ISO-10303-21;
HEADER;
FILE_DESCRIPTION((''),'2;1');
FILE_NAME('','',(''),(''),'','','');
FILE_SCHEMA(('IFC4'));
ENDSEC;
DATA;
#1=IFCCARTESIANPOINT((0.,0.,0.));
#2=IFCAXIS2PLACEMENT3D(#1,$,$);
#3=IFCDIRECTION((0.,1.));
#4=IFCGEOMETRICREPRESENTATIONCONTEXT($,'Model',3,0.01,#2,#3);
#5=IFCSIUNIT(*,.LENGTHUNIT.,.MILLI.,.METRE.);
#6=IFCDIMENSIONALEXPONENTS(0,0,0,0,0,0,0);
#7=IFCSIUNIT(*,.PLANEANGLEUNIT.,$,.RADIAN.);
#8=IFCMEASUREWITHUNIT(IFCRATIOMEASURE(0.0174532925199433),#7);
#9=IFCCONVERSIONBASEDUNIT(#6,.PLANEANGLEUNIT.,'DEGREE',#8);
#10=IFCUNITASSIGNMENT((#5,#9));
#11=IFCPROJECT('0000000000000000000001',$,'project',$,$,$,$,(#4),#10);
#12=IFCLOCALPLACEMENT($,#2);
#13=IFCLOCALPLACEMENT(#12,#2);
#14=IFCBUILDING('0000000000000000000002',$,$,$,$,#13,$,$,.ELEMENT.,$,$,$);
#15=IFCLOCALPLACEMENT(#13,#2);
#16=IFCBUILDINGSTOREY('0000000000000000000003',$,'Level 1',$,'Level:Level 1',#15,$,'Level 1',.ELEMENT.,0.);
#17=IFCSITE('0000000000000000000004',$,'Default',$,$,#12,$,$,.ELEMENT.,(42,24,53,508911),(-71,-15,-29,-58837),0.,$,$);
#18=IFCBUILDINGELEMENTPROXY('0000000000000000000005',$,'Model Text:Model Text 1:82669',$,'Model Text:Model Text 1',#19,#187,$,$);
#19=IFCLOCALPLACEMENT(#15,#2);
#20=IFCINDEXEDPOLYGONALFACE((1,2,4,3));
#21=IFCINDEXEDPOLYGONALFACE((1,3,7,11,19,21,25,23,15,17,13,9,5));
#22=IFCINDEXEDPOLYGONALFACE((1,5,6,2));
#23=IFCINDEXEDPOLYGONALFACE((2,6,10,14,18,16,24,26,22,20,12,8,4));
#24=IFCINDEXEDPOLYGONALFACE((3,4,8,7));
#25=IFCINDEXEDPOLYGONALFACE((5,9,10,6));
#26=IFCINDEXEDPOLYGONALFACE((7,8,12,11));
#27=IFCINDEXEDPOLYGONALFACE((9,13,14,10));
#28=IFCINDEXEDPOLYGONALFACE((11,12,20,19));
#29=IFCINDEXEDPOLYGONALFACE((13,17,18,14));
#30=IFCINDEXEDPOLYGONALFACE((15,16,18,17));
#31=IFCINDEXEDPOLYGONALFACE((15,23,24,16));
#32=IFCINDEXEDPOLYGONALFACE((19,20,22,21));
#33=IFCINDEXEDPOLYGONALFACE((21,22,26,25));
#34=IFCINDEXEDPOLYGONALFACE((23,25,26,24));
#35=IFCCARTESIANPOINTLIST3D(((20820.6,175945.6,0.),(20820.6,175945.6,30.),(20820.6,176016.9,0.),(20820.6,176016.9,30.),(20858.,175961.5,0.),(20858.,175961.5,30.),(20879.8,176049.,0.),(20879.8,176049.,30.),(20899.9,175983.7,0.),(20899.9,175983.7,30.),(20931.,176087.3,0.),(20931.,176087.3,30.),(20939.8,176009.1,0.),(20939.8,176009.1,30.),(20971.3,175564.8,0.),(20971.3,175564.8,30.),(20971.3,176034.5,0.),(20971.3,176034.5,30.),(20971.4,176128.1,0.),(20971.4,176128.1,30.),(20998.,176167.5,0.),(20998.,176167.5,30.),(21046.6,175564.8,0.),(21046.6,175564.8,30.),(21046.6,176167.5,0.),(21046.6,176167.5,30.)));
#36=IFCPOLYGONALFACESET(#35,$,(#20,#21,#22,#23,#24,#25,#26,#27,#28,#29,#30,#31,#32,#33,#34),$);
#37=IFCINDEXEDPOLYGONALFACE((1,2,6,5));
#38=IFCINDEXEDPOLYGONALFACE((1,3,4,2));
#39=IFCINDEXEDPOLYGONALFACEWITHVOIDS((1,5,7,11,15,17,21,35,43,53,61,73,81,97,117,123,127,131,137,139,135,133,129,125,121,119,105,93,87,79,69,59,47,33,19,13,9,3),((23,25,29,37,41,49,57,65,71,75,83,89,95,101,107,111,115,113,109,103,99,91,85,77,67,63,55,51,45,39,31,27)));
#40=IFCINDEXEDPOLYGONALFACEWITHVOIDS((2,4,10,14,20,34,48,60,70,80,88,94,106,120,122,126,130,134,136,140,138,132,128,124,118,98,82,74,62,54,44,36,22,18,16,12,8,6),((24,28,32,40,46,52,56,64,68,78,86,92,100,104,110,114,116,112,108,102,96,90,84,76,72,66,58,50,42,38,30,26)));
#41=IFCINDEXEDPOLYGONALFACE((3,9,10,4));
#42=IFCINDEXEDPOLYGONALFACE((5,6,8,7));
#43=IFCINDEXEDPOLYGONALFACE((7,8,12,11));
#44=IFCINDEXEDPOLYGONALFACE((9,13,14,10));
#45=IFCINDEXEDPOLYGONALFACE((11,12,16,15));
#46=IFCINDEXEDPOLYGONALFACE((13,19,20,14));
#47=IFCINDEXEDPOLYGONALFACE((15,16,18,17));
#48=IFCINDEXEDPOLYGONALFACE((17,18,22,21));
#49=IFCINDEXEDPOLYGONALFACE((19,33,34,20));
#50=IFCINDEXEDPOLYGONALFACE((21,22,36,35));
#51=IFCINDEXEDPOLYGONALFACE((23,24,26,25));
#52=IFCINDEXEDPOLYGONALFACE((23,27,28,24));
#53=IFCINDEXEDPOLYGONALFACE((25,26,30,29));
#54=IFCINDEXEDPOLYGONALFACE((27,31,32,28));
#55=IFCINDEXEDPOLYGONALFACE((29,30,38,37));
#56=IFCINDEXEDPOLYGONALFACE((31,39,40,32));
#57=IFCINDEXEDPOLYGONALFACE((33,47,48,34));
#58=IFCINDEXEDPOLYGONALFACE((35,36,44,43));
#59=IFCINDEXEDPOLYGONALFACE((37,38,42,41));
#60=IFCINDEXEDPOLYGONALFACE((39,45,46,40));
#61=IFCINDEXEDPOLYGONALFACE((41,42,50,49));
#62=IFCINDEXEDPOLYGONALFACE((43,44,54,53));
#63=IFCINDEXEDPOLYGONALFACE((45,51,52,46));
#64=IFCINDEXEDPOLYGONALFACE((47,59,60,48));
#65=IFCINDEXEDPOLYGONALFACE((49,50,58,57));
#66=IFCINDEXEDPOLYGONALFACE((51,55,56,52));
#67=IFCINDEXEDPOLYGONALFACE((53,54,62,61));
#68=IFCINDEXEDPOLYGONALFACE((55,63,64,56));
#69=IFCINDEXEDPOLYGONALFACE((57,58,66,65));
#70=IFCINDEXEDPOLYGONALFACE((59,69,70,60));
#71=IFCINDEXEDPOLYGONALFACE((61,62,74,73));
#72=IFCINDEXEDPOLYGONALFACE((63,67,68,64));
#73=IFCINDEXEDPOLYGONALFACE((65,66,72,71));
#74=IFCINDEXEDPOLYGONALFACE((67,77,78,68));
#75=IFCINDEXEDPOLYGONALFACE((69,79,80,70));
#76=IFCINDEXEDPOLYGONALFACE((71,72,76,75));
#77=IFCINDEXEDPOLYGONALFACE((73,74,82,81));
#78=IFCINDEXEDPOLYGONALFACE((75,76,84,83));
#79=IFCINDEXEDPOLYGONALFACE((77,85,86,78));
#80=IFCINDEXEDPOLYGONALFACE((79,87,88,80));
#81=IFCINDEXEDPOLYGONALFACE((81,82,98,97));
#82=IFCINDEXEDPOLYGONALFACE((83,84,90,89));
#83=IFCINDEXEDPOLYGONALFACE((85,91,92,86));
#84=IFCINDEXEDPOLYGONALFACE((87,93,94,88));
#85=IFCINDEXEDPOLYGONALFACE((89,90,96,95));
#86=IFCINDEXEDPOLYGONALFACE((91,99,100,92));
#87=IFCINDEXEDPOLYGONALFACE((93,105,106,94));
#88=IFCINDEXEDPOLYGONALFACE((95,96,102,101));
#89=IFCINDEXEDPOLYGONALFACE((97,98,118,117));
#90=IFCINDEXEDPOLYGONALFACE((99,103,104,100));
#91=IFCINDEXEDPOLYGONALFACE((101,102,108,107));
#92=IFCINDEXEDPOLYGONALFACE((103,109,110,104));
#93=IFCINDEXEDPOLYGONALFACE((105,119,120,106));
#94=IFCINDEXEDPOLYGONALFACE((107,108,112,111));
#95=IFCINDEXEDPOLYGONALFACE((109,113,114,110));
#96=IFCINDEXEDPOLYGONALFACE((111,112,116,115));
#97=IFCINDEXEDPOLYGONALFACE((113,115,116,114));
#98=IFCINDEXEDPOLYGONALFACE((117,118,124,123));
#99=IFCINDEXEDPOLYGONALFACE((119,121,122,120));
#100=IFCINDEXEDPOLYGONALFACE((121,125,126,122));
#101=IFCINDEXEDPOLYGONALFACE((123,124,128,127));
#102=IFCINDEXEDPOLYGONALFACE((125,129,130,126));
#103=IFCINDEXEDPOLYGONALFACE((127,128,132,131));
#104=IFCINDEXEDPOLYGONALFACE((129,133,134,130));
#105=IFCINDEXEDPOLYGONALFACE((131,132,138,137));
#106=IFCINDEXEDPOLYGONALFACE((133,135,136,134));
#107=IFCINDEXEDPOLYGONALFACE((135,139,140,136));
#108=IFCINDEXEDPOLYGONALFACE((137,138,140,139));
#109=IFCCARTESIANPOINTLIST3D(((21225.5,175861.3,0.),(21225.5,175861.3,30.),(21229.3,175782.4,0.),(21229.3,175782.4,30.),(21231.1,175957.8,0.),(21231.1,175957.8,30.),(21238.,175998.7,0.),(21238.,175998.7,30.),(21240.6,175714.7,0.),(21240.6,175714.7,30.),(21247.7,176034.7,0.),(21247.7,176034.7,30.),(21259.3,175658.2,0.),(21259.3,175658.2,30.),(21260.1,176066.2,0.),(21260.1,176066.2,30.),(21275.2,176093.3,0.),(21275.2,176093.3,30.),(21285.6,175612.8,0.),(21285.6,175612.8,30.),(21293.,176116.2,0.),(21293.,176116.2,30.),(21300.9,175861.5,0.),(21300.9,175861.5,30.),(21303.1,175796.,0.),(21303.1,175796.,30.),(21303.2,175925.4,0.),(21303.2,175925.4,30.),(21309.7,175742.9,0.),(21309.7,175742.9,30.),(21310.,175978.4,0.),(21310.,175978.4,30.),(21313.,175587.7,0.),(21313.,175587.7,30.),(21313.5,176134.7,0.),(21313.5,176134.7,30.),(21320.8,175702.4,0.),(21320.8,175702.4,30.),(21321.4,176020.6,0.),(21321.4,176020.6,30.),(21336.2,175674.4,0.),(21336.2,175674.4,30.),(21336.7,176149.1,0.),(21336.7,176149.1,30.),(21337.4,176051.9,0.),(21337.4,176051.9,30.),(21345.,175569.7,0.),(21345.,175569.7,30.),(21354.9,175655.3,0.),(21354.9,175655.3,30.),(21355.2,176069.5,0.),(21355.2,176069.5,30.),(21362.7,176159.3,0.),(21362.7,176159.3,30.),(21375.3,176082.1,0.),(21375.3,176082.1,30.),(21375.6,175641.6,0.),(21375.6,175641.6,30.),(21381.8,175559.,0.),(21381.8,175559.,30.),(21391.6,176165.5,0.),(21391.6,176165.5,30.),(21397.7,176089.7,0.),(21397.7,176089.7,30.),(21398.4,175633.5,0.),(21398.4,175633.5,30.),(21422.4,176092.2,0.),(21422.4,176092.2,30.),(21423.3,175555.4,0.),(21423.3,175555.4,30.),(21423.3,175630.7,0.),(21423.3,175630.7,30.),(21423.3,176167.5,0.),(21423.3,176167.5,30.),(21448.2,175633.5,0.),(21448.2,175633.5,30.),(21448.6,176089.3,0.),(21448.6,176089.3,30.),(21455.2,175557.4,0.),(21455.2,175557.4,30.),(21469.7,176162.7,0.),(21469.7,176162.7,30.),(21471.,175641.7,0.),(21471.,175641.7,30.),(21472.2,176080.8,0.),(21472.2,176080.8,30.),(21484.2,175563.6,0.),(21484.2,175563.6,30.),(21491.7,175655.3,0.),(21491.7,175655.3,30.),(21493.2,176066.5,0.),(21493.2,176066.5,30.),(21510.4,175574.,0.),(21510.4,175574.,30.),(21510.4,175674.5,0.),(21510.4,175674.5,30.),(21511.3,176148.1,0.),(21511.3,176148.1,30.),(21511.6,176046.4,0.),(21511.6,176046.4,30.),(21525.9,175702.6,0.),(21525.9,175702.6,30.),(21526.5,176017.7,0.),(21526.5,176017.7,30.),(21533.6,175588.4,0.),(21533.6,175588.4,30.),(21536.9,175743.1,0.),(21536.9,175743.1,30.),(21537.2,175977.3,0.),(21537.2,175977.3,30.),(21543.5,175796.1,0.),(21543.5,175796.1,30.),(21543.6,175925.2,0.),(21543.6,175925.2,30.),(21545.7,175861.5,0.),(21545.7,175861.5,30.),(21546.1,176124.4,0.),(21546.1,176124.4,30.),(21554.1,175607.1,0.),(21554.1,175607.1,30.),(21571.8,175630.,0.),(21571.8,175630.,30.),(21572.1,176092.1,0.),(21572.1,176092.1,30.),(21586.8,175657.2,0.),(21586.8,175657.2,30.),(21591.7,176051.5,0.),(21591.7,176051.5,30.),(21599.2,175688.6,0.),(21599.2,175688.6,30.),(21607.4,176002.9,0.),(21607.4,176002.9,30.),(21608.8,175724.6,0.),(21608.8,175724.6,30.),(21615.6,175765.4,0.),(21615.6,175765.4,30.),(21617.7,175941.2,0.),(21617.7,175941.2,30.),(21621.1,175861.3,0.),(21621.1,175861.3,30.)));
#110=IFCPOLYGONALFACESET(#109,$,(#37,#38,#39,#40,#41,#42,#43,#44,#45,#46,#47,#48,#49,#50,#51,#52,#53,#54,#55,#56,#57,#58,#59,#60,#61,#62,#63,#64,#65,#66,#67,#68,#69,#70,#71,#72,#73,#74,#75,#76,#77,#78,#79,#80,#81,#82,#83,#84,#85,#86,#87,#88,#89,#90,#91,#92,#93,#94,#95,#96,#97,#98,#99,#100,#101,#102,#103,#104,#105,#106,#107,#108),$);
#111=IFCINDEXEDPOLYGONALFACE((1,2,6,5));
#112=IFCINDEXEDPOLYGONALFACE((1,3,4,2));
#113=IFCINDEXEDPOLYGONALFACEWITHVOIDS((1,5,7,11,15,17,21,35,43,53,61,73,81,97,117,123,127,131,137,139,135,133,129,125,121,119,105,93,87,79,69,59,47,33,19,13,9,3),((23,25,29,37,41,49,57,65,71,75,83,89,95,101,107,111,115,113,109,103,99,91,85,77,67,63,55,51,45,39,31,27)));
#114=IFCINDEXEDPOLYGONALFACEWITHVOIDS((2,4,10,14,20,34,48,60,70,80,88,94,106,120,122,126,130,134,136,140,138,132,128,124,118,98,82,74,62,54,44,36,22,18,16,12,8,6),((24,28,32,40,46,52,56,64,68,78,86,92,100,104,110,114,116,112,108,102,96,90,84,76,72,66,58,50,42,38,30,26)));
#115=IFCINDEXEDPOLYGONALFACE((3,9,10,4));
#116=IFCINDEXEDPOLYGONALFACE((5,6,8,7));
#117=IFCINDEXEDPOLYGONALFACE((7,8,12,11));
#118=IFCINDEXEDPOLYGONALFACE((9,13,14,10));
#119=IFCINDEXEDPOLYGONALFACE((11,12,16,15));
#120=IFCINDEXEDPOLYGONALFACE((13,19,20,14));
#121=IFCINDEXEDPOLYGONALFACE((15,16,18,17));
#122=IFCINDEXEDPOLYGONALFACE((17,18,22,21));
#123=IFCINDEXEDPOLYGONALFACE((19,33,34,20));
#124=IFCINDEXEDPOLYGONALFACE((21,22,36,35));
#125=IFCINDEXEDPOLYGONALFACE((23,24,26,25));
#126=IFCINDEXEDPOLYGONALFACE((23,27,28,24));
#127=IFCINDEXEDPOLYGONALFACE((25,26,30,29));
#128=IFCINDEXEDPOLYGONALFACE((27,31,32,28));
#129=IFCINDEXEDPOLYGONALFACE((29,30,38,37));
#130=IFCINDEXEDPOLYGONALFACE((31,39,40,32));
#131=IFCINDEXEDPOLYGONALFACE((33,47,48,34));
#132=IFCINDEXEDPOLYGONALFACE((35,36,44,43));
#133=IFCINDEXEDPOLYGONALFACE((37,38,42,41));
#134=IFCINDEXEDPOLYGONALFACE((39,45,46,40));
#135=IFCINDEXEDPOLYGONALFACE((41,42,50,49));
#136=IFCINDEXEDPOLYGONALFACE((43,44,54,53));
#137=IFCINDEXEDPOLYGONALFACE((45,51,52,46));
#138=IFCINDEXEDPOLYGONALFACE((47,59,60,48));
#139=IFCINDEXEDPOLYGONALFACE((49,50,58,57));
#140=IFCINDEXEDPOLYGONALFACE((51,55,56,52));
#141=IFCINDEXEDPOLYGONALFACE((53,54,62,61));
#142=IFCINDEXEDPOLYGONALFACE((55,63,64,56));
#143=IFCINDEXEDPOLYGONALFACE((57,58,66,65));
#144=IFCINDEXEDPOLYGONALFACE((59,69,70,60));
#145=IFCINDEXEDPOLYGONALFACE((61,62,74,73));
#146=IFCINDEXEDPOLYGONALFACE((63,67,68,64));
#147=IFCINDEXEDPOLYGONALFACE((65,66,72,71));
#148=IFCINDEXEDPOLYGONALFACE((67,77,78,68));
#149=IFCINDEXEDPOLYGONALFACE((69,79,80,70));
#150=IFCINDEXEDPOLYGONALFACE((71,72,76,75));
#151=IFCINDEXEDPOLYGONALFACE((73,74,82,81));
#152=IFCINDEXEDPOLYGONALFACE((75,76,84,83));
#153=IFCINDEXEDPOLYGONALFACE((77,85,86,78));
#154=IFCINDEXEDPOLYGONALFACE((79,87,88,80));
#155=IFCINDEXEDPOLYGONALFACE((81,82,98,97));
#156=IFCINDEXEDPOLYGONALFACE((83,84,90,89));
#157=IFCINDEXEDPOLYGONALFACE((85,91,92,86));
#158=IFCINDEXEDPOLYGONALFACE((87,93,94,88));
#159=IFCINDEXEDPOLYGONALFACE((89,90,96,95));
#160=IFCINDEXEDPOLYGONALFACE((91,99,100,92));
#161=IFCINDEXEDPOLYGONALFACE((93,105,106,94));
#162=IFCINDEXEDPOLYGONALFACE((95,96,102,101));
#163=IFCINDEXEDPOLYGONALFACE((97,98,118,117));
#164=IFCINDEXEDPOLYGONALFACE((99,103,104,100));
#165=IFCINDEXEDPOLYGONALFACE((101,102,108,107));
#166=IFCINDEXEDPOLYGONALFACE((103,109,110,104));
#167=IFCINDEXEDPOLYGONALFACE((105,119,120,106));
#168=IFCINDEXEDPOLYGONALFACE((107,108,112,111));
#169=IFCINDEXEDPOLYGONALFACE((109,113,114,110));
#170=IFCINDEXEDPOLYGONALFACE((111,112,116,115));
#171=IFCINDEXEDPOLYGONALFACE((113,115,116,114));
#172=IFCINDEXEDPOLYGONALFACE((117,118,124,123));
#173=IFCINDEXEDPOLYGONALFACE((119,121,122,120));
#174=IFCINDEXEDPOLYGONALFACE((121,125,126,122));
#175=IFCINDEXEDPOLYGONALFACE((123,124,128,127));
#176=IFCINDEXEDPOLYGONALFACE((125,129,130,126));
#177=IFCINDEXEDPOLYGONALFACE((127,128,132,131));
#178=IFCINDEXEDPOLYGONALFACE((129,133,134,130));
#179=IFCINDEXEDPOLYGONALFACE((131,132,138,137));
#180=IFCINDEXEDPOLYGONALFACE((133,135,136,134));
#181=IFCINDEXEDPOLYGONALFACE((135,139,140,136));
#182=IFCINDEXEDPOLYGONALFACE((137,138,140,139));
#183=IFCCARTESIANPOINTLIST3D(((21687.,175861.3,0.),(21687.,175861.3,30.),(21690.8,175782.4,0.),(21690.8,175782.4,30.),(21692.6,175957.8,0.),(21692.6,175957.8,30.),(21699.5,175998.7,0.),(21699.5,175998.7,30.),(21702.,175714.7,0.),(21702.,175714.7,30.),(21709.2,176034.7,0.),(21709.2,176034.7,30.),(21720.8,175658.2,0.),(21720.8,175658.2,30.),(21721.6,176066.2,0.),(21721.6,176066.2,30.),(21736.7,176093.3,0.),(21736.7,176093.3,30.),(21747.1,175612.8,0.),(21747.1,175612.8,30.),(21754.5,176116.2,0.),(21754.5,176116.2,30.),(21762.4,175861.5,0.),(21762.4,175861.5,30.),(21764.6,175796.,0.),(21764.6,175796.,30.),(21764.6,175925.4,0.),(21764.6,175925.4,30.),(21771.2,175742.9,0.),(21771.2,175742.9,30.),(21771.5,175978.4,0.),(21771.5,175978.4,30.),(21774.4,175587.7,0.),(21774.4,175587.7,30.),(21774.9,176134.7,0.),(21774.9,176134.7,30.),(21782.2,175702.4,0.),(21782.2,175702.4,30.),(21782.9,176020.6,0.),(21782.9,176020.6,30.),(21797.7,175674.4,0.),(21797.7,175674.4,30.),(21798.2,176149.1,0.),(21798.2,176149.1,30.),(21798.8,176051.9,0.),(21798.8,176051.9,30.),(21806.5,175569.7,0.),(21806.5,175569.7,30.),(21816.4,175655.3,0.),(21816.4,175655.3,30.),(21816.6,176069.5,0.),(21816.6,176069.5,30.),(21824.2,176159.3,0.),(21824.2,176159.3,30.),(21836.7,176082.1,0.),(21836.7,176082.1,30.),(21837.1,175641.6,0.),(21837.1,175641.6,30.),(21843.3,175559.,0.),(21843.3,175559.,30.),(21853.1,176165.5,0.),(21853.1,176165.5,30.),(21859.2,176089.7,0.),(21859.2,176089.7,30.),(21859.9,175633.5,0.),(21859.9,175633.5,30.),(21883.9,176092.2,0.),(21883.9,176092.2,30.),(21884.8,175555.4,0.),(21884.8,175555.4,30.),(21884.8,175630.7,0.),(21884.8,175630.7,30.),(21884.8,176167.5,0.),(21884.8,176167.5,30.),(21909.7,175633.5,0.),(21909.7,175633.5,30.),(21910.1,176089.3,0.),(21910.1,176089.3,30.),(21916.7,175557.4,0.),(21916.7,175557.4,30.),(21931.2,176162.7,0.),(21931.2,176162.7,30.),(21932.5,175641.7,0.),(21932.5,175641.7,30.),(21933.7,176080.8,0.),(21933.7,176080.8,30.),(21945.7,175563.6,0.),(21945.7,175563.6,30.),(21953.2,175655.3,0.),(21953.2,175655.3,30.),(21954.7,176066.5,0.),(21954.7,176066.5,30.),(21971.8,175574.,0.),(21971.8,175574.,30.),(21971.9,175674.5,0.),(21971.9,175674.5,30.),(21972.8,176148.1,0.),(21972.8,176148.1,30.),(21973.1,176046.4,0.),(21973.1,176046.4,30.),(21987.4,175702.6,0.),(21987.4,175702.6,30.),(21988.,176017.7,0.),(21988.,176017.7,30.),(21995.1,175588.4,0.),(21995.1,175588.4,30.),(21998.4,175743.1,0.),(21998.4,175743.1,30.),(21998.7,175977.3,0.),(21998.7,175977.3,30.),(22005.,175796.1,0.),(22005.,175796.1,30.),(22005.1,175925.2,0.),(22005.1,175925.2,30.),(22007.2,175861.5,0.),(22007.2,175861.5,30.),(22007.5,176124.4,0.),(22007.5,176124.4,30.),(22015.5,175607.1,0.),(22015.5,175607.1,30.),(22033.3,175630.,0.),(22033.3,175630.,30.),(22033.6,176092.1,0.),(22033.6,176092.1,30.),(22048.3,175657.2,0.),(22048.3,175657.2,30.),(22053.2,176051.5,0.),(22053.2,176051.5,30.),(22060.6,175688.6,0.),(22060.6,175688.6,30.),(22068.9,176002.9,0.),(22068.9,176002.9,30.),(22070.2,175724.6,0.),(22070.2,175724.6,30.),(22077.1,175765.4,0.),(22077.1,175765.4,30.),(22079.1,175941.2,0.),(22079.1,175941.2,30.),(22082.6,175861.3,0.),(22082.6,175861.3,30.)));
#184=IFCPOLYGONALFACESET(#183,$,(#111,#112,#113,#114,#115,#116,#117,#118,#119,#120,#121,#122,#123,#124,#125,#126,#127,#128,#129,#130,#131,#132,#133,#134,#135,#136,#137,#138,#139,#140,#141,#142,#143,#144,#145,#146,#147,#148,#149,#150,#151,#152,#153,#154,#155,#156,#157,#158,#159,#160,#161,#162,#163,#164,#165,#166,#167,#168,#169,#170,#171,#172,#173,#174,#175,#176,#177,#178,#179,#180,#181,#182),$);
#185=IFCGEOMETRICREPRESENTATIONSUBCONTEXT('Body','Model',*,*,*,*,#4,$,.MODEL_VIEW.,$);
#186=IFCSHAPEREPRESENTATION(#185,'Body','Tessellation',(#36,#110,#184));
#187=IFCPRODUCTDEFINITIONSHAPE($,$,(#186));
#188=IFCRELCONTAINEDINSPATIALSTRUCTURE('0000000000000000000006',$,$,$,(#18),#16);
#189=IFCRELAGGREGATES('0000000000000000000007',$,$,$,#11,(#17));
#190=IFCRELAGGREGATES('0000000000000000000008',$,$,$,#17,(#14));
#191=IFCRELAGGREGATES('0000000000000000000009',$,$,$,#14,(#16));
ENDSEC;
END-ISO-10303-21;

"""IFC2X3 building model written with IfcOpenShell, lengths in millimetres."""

from ifc_helpers import new_model, entity, si_unit, converted_unit, direction, frame, origin, place, context, subcontext, project, spatial, polyline, outline, extrude, element, save


model = new_model("IFC2X3")

# Units and contexts
model_context = context("Model", 3, precision=0.01, world=origin(), true_north=direction((0.0, 1.0)))
body_context = subcontext(model_context, "Body", "Model", "MODEL_VIEW")
ifc_project = project(units=[si_unit("LENGTHUNIT", "METRE", prefix="MILLI"), converted_unit("PLANEANGLEUNIT", "DEGREE", entity("IfcRatioMeasure", 0.0174532925199433), si_unit("PLANEANGLEUNIT", "RADIAN"), dimensions=[0, 0, 0, 0, 0, 0, 0])], contexts=[model_context])

# Site, building, storey
site_placement = place(None, origin())
site = spatial("IfcSite", under=ifc_project, at=site_placement, Name="Default", CompositionType="ELEMENT", RefLatitude=(42, 24, 53, 508911), RefLongitude=(-71, -15, -29, -58837), RefElevation=0.0)
building_placement = place(site_placement, origin())
building = spatial("IfcBuilding", under=site, at=building_placement, CompositionType="ELEMENT")
storey_placement = place(building_placement, origin())
storey = spatial("IfcBuildingStorey", under=building, at=storey_placement, Name="Level 1", ObjectType="Level:Level 1", LongName="Level 1", CompositionType="ELEMENT", Elevation=0.0)

# Building element proxy
proxy_1_placement = place(storey_placement, origin())
element("IfcBuildingElementProxy", 1, at=proxy_1_placement, inside=storey, Name="Model Text:Model Text 1:82669", ObjectType="Model Text:Model Text 1", context=body_context, shape_type="SweptSolid", body=[
    extrude(outline(polyline([(-410.6, -111.6), (192.1, -111.6), (192.1, -63.1), (152.7, -36.4), (111.9, 4.0), (73.6, 55.2), (41.4, 114.4), (-29.8, 114.4), (-13.9, 77.0), (8.3, 35.1), (33.7, -4.8), (59.1, -36.3), (-410.6, -36.3), (-410.6, -111.6)])), frame((20935.0, 175975.4, 0.0), z_axis=(0.0, 0.0, 1.0), x_axis=(0.0, 1.0, 0.0)), (0.0, 0.0, 1.0), 30.0),
    extrude(outline(polyline([(-10.6, -198.7), (68.3, -198.7), (136.5, -190.7), (193.9, -174.7), (240.5, -150.6), (266.9, -124.4), (286.3, -93.2), (298.8, -57.0), (304.3, -15.7), (303.8, 16.2), (299.0, 45.5), (289.9, 72.1), (276.6, 96.0), (258.9, 117.3), (236.9, 136.2), (210.4, 152.5), (179.6, 166.3), (144.1, 177.6), (103.7, 186.3), (8.2, 196.4), (-71.8, 196.7), (-134.0, 189.4), (-183.3, 176.1), (-224.7, 158.4), (-258.2, 133.9), (-283.5, 100.3), (-300.1, 59.5), (-307.1, 13.4), (-306.6, -18.4), (-301.8, -47.5), (-292.8, -74.0), (-279.6, -97.9), (-262.0, -119.2), (-240.0, -138.1), (-213.6, -154.5), (-182.8, -168.4), (-147.3, -179.8), (-106.7, -188.6), (-10.6, -198.7)]), holes=[polyline([(-7.2, -123.5), (-71.0, -118.2), (-123.6, -108.8), (-165.2, -95.4), (-195.7, -78.0), (-212.4, -59.4), (-224.1, -38.7), (-230.6, -15.9), (-231.9, 8.9), (-227.8, 35.0), (-218.1, 58.1), (-202.8, 78.4), (-182.0, 95.8), (-152.6, 109.4), (-111.7, 118.1), (-59.4, 122.0), (4.4, 121.1), (69.6, 115.8), (122.2, 106.7), (162.2, 93.7), (189.5, 77.0), (207.7, 57.4), (220.4, 36.0), (227.5, 12.8), (229.1, -12.1), (225.2, -36.8), (215.9, -59.2), (201.3, -79.3), (181.4, -97.1), (152.6, -111.2), (111.6, -120.3), (58.3, -124.4), (-7.2, -123.5)])]), frame((21424.6, 175860.1, 0.0), z_axis=(0.0, 0.0, 1.0), x_axis=(0.047515, -0.998871, 0.0)), (0.0, 0.0, 1.0), 30.0),
    extrude(outline(polyline([(-10.6, -198.7), (68.3, -198.7), (136.5, -190.7), (193.9, -174.7), (240.5, -150.6), (266.9, -124.4), (286.3, -93.2), (298.8, -57.0), (304.3, -15.7), (303.8, 16.2), (299.0, 45.5), (289.9, 72.1), (276.6, 96.0), (258.9, 117.3), (236.9, 136.2), (210.4, 152.5), (179.6, 166.3), (144.1, 177.6), (103.7, 186.3), (8.2, 196.4), (-71.8, 196.7), (-134.0, 189.4), (-183.3, 176.1), (-224.7, 158.4), (-258.2, 133.9), (-283.5, 100.3), (-300.1, 59.5), (-307.1, 13.4), (-306.6, -18.4), (-301.8, -47.5), (-292.8, -74.0), (-279.6, -97.9), (-262.0, -119.2), (-240.0, -138.1), (-213.6, -154.5), (-182.8, -168.4), (-147.3, -179.8), (-106.7, -188.6), (-10.6, -198.7)]), holes=[polyline([(-7.2, -123.5), (-71.0, -118.2), (-123.6, -108.8), (-165.2, -95.4), (-195.7, -78.0), (-212.4, -59.4), (-224.1, -38.7), (-230.6, -15.9), (-231.9, 8.9), (-227.8, 35.0), (-218.1, 58.1), (-202.8, 78.4), (-182.0, 95.8), (-152.6, 109.4), (-111.7, 118.1), (-59.4, 122.0), (4.4, 121.1), (69.6, 115.8), (122.2, 106.7), (162.2, 93.7), (189.5, 77.0), (207.7, 57.4), (220.4, 36.0), (227.5, 12.8), (229.1, -12.1), (225.2, -36.8), (215.9, -59.2), (201.3, -79.3), (181.4, -97.1), (152.6, -111.2), (111.6, -120.3), (58.3, -124.4), (-7.2, -123.5)])]), frame((21886.0, 175860.1, 0.0), z_axis=(0.0, 0.0, 1.0), x_axis=(0.047515, -0.998871, 0.0)), (0.0, 0.0, 1.0), 30.0),
])

save(model, "model.ifc")
